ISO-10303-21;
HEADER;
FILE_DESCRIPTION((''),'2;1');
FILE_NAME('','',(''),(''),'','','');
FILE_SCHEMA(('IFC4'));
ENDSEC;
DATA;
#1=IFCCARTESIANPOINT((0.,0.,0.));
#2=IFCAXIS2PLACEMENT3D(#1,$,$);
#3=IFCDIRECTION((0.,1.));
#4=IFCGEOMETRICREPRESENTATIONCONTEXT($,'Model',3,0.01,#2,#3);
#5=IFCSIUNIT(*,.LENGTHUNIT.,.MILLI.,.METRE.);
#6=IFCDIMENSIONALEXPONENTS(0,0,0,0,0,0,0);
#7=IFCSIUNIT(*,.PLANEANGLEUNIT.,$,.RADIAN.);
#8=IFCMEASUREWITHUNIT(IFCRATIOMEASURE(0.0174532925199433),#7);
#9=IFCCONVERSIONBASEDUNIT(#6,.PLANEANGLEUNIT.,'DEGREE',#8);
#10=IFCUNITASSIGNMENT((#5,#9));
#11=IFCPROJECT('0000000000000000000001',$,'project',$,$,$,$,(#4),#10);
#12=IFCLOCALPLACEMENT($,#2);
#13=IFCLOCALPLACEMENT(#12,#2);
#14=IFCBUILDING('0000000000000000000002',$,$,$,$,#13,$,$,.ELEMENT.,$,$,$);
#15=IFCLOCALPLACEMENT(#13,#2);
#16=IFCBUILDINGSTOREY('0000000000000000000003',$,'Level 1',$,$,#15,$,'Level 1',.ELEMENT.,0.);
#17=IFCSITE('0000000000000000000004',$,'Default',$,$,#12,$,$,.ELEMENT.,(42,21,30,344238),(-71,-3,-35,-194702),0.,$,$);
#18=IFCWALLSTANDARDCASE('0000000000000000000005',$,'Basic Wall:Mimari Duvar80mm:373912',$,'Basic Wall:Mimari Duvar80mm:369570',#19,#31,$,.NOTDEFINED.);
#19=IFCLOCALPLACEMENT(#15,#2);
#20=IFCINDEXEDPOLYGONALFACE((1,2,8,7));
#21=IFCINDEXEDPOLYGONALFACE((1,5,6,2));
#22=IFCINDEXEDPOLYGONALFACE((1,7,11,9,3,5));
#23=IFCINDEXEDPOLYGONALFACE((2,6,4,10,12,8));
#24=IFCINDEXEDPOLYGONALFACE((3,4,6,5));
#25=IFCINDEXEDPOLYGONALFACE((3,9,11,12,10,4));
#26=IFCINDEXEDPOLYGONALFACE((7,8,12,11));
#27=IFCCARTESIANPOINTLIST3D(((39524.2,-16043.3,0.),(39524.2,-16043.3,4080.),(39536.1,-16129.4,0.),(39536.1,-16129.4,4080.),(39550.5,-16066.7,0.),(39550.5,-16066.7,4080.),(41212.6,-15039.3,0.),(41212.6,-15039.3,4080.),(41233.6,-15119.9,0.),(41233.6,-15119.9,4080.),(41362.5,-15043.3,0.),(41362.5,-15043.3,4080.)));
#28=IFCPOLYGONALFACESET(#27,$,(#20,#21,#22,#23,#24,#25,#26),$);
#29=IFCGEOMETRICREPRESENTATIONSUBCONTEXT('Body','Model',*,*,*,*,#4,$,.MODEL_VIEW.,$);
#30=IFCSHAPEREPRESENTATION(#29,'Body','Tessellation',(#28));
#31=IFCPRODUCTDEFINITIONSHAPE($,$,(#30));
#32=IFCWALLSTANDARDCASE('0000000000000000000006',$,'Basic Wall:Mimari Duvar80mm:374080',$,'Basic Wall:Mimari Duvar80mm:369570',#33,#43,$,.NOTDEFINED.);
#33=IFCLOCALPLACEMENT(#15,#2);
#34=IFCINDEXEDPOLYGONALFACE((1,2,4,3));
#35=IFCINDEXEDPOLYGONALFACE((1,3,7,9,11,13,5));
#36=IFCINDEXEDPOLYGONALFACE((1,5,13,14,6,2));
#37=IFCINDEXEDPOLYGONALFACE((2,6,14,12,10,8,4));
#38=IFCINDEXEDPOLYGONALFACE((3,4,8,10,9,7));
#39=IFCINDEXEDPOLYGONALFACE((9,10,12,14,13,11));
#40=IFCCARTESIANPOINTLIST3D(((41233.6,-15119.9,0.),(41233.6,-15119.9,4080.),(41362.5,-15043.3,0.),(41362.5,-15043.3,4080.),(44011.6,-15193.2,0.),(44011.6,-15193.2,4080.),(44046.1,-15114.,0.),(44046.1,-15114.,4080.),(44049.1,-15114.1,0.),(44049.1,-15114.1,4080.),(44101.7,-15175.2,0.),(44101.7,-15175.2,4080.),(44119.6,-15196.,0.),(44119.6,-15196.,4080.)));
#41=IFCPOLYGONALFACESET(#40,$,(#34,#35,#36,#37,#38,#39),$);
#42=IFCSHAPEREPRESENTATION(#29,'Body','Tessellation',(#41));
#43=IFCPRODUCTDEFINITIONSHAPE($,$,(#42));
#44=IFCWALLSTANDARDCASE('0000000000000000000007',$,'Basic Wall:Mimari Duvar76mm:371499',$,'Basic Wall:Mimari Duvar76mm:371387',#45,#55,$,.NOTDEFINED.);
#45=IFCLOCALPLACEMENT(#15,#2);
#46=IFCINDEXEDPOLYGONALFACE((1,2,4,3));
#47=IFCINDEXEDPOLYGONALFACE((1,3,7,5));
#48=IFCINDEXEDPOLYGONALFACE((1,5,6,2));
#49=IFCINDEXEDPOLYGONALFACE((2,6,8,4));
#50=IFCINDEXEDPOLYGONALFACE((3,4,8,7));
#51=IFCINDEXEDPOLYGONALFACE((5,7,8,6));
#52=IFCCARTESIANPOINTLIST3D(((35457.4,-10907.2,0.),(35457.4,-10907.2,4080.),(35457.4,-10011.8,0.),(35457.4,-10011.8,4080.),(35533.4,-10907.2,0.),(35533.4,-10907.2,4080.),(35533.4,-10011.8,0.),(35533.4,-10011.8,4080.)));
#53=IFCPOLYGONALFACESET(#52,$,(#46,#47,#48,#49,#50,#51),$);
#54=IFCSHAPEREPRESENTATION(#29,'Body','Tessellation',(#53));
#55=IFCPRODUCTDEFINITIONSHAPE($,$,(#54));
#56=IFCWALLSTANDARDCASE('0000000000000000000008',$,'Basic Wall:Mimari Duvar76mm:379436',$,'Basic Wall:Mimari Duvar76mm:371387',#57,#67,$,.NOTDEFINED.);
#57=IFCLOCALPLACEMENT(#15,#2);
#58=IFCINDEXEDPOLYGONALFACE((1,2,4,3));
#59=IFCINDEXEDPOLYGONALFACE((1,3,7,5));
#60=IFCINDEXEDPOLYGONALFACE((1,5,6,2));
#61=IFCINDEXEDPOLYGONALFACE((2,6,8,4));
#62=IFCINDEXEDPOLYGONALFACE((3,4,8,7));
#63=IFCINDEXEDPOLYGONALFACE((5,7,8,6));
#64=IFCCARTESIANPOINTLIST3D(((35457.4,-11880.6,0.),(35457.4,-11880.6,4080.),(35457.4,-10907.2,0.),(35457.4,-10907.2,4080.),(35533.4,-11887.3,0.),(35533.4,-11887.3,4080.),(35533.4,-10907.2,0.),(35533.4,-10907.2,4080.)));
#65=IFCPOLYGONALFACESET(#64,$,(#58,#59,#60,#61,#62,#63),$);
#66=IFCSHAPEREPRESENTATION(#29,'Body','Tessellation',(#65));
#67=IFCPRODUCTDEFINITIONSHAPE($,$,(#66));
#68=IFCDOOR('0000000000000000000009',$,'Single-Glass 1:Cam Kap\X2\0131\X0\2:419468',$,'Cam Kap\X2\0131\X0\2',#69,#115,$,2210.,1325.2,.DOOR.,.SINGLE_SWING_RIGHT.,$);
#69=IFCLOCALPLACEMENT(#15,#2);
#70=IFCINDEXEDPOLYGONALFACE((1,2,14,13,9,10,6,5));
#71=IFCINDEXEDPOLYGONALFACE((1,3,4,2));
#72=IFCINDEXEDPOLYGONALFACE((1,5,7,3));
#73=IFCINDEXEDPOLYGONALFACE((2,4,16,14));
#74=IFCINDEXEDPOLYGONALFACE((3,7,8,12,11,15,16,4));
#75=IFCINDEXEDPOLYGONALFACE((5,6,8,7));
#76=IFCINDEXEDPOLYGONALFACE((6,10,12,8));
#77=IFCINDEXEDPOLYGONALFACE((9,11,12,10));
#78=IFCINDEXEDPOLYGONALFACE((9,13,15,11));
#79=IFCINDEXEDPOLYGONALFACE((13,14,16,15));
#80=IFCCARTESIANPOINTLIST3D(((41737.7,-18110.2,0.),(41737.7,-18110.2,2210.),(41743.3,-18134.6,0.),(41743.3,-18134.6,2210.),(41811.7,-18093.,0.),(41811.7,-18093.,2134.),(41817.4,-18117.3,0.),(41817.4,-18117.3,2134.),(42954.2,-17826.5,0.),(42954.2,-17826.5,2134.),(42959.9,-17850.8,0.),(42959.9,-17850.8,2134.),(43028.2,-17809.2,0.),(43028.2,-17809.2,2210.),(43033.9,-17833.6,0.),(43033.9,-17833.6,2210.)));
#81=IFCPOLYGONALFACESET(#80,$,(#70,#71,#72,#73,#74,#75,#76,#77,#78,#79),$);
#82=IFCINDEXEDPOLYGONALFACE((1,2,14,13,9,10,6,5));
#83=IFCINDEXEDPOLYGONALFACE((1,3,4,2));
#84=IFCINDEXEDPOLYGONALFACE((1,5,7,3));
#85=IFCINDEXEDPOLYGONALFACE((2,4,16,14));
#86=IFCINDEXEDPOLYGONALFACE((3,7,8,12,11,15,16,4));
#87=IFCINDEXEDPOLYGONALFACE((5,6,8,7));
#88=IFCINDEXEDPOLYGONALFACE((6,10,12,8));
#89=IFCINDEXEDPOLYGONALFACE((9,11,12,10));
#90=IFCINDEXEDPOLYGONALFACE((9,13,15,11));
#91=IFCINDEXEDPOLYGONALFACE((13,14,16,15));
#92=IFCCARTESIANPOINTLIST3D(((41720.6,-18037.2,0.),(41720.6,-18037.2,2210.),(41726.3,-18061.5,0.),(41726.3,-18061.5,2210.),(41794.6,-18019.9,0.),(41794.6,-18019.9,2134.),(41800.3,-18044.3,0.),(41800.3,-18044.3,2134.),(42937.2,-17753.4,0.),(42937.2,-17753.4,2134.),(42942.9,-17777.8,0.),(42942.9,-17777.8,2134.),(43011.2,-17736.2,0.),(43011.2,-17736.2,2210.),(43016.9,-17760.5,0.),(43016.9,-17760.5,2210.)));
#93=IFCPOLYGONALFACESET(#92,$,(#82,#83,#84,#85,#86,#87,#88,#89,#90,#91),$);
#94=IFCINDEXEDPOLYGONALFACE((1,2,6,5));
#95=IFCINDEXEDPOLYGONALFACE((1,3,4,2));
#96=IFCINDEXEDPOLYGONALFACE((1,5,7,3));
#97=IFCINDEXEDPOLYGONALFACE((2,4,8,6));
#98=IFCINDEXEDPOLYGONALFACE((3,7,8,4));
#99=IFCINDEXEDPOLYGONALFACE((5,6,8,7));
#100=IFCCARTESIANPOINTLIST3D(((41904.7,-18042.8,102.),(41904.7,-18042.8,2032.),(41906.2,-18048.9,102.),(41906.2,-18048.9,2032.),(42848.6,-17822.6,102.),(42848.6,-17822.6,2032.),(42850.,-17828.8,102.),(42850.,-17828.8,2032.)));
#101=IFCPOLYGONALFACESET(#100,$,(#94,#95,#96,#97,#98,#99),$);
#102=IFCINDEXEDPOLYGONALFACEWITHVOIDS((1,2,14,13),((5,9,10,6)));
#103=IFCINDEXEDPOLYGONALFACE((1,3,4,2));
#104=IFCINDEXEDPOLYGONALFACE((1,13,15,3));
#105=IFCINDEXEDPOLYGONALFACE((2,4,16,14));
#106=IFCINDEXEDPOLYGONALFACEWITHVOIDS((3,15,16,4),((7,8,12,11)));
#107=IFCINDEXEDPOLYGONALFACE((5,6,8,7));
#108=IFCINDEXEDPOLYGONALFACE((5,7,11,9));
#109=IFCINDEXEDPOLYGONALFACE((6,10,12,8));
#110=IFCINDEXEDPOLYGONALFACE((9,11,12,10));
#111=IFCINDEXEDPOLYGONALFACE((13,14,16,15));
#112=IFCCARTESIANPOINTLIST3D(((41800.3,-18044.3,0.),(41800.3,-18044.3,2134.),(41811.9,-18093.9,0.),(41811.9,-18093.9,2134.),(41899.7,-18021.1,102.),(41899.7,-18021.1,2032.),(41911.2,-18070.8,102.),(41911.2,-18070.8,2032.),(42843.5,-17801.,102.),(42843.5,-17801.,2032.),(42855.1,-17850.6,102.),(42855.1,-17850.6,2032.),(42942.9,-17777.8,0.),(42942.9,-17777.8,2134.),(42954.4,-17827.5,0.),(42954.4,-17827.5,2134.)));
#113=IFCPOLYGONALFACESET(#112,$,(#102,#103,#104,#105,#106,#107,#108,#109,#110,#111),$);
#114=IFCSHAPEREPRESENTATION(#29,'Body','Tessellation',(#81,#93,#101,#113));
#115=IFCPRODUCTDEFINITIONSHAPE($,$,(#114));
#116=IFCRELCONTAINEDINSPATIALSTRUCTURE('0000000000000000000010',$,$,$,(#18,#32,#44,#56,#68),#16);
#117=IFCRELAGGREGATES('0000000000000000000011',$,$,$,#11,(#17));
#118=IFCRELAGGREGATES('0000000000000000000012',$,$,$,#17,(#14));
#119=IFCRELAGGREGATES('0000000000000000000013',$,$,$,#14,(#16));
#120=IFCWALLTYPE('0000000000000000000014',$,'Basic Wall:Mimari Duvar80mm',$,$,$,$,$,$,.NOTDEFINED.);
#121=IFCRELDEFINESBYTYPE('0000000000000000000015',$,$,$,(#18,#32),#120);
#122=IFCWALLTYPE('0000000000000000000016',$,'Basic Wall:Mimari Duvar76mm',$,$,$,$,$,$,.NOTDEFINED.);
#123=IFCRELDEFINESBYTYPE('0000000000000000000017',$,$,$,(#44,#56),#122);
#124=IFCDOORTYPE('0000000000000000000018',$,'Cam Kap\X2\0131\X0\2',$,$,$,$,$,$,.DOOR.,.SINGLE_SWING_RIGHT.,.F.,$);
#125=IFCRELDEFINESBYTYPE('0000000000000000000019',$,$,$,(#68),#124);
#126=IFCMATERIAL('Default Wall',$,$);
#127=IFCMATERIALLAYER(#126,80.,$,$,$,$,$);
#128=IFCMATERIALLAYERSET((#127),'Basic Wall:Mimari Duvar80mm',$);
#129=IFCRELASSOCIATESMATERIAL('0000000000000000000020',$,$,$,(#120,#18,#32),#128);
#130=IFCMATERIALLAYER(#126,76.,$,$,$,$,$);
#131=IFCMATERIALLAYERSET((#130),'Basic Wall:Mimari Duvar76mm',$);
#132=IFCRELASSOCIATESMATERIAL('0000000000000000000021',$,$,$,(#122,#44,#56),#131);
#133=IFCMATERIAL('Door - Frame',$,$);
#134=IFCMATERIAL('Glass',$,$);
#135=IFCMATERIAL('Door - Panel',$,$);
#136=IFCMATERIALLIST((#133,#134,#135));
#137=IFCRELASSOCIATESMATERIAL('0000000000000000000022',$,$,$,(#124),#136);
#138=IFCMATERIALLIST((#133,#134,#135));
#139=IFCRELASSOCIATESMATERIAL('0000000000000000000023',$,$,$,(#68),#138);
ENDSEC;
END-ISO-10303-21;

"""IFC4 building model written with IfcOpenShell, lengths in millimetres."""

from ifc_helpers import new_model, entity, si_unit, converted_unit, direction, frame, frame_2d, origin, origin_2d_with_axis, place, context, subcontext, project, spatial, polyline, rectangle, outline, extrude, source, transform, mapped, material, material_list, layer, layer_set, layer_usage, type_object, type_shapes, element, save


model = new_model("IFC4")

# Units and contexts
model_context = context("Model", 3, precision=0.01, world=origin(), true_north=direction((0.0, 1.0)))
body_context = subcontext(model_context, "Body", "Model", "MODEL_VIEW")
ifc_project = project(units=[si_unit("LENGTHUNIT", "METRE", prefix="MILLI"), converted_unit("PLANEANGLEUNIT", "DEGREE", entity("IfcRatioMeasure", 0.0174532925199433), si_unit("PLANEANGLEUNIT", "RADIAN"), dimensions=[0, 0, 0, 0, 0, 0, 0])], contexts=[model_context])

# Site, building, storey
site_placement = place(None, origin())
site = spatial("IfcSite", under=ifc_project, at=site_placement, Name="Default", CompositionType="ELEMENT", RefLatitude=(42, 21, 30, 344238), RefLongitude=(-71, -3, -35, -194702), RefElevation=0.0)
building_placement = place(site_placement, origin())
building = spatial("IfcBuilding", under=site, at=building_placement, CompositionType="ELEMENT")
storey_placement = place(building_placement, origin())
storey = spatial("IfcBuildingStorey", under=building, at=storey_placement, Name="Level 1", LongName="Level 1", CompositionType="ELEMENT", Elevation=0.0)

# Shared definitions
ifc_material_1 = material(Name="Glass")

# Walls
ifc_material_2 = material(Name="Default Wall")
ifc_layer_1 = layer(ifc_material_2, 80.0)
ifc_layer_set_1 = layer_set([ifc_layer_1], Name="Basic Wall:Mimari Duvar80mm")
wall_type_1 = type_object("IfcWallType", Name="Basic Wall:Mimari Duvar80mm", PredefinedType="NOTDEFINED", material=ifc_layer_set_1)
ifc_layer_usage_1 = layer_usage(ifc_layer_set_1, "AXIS2", "NEGATIVE", 40.0)
wall_1_placement = place(storey_placement, frame((39515.6, -16095.0, 0.0), z_axis=(0.0, 0.0, 1.0), x_axis=(0.85951, 0.511119, 0.0)))
element("IfcWallStandardCase", 1, at=wall_1_placement, inside=storey, type_object=wall_type_1, material=ifc_layer_usage_1, Name="Basic Wall:Mimari Duvar80mm:373912", ObjectType="Basic Wall:Mimari Duvar80mm:369570", PredefinedType="NOTDEFINED", context=body_context, shape_type="SweptSolid", body=[
    extrude(outline(polyline([(2124.9, -40.0), (1998.1, 40.0), (33.8, 40.0), (44.4, 6.4), (0.0, -40.0), (1975.0, -40.0), (2124.9, -40.0)])), origin(), (0.0, 0.0, 1.0), 4080.0),
])
ifc_layer_usage_2 = layer_usage(ifc_layer_set_1, "AXIS2", "NEGATIVE", 40.0)
wall_2_placement = place(storey_placement, frame((41234.7, -15079.9, 0.0), z_axis=(0.0, 0.0, 1.0), x_axis=(0.999652, -0.026363, 0.0)))
element("IfcWallStandardCase", 2, at=wall_2_placement, inside=storey, type_object=wall_type_1, material=ifc_layer_usage_2, Name="Basic Wall:Mimari Duvar80mm:374080", ObjectType="Basic Wall:Mimari Duvar80mm:369570", PredefinedType="NOTDEFINED", context=body_context, shape_type="SweptSolid", body=[
    extrude(outline(polyline([(2886.9, -40.0), (2868.5, -19.7), (2814.3, 40.0), (2811.3, 40.0), (126.8, 40.0), (0.0, -40.0), (2778.9, -40.0), (2886.9, -40.0)])), origin(), (0.0, 0.0, 1.0), 4080.0),
])
ifc_layer_2 = layer(ifc_material_2, 76.0)
ifc_layer_set_2 = layer_set([ifc_layer_2], Name="Basic Wall:Mimari Duvar76mm")
ifc_layer_usage_3 = layer_usage(ifc_layer_set_2, "AXIS2", "NEGATIVE", 38.0)
wall_type_2 = type_object("IfcWallType", Name="Basic Wall:Mimari Duvar76mm", PredefinedType="NOTDEFINED", material=ifc_layer_set_2)
wall_3_placement = place(storey_placement, frame((35495.4, -10907.2, 0.0), z_axis=(0.0, 0.0, 1.0), x_axis=(0.0, 1.0, 0.0)))
element("IfcWallStandardCase", 3, at=wall_3_placement, inside=storey, type_object=wall_type_2, material=ifc_layer_usage_3, Name="Basic Wall:Mimari Duvar76mm:371499", ObjectType="Basic Wall:Mimari Duvar76mm:371387", PredefinedType="NOTDEFINED", context=body_context, shape_type="SweptSolid", body=[
    extrude(rectangle(XDim=895.5, YDim=76.0, at=frame_2d((447.7, 0.0), x_axis=(-1.0, 0.0))), origin(), (0.0, 0.0, 1.0), 4080.0),
])
ifc_layer_usage_4 = layer_usage(ifc_layer_set_2, "AXIS2", "NEGATIVE", 38.0)
wall_4_placement = place(storey_placement, frame((35495.4, -10907.2, 0.0), z_axis=(0.0, 0.0, 1.0), x_axis=(0.0, -1.0, 0.0)))
element("IfcWallStandardCase", 4, at=wall_4_placement, inside=storey, type_object=wall_type_2, material=ifc_layer_usage_4, Name="Basic Wall:Mimari Duvar76mm:379436", ObjectType="Basic Wall:Mimari Duvar76mm:371387", PredefinedType="NOTDEFINED", context=body_context, shape_type="SweptSolid", body=[
    extrude(outline(polyline([(973.4, -38.0), (980.1, 38.0), (0.0, 38.0), (0.0, -38.0), (973.4, -38.0)])), origin(), (0.0, 0.0, 1.0), 4080.0),
])

# Door
ifc_material_3 = material(Name="Door - Frame")
ifc_material_4 = material(Name="Door - Panel")
ifc_material_list_1 = material_list([ifc_material_3, ifc_material_1, ifc_material_4])
ifc_material_list_2 = material_list([ifc_material_3, ifc_material_1, ifc_material_4])
door_type = type_object("IfcDoorType", Name="Cam Kapı2", OperationType="SINGLE_SWING_RIGHT", ParameterTakesPrecedence=False, PredefinedType="DOOR", material=ifc_material_list_2)
shared_shape_1 = source(origin(), body_context, "Body", "SweptSolid", [
    extrude(outline(polyline([(-586.6, -1048.0), (-586.6, 1086.0), (-662.6, 1086.0), (-662.6, -1124.0), (662.6, -1124.0), (662.6, 1086.0), (586.6, 1086.0), (586.6, -1048.0), (-586.6, -1048.0)])), frame((586.6, -25.0, 1086.0), z_axis=(0.0, -1.0, 0.0), x_axis=(-1.0, 0.0, 0.0)), (0.0, 0.0, -1.0), 25.0),
    extrude(outline(polyline([(-586.6, -1048.0), (-586.6, 1086.0), (-662.6, 1086.0), (-662.6, -1124.0), (662.6, -1124.0), (662.6, 1086.0), (586.6, 1086.0), (586.6, -1048.0), (-586.6, -1048.0)])), frame((586.6, 50.0, 1086.0), z_axis=(0.0, -1.0, 0.0), x_axis=(-1.0, 0.0, 0.0)), (0.0, 0.0, -1.0), 25.0),
    extrude(rectangle(XDim=6.3, YDim=969.2, at=origin_2d_with_axis()), frame((586.6, 24.6, 102.0), z_axis=(0.0, 0.0, 1.0), x_axis=(0.0, 1.0, 0.0)), (0.0, 0.0, 1.0), 1930.0),
    extrude(outline(polyline([(-1067.0, -586.6), (1067.0, -586.6), (1067.0, 586.6), (-1067.0, 586.6), (-1067.0, -586.6)]), holes=[polyline([(-965.0, 484.6), (965.0, 484.6), (965.0, -484.6), (-965.0, -484.6), (-965.0, 484.6)])]), frame((586.6, -1.0, 1067.0), z_axis=(0.0, 1.0, 0.0), x_axis=(0.0, 0.0, -1.0)), (0.0, 0.0, 1.0), 51.0),
])
type_shapes(door_type, [shared_shape_1])
door_placement = place(storey_placement, frame((41811.7, -18093.0, 0.0), z_axis=(0.0, 0.0, 1.0), x_axis=(0.973861, 0.227145, 0.0)))
element("IfcDoor", 5, at=door_placement, inside=storey, type_object=door_type, material=ifc_material_list_1, Name="Single-Glass 1:Cam Kapı2:419468", ObjectType="Cam Kapı2", OperationType="SINGLE_SWING_RIGHT", OverallHeight=2210.0, OverallWidth=1325.2, PredefinedType="DOOR", context=body_context, shape_type="MappedRepresentation", body=[
    mapped(shared_shape_1, transform((0.0, 0.0, 0.0), scale=1.0)),
])

save(model, "model.ifc")
